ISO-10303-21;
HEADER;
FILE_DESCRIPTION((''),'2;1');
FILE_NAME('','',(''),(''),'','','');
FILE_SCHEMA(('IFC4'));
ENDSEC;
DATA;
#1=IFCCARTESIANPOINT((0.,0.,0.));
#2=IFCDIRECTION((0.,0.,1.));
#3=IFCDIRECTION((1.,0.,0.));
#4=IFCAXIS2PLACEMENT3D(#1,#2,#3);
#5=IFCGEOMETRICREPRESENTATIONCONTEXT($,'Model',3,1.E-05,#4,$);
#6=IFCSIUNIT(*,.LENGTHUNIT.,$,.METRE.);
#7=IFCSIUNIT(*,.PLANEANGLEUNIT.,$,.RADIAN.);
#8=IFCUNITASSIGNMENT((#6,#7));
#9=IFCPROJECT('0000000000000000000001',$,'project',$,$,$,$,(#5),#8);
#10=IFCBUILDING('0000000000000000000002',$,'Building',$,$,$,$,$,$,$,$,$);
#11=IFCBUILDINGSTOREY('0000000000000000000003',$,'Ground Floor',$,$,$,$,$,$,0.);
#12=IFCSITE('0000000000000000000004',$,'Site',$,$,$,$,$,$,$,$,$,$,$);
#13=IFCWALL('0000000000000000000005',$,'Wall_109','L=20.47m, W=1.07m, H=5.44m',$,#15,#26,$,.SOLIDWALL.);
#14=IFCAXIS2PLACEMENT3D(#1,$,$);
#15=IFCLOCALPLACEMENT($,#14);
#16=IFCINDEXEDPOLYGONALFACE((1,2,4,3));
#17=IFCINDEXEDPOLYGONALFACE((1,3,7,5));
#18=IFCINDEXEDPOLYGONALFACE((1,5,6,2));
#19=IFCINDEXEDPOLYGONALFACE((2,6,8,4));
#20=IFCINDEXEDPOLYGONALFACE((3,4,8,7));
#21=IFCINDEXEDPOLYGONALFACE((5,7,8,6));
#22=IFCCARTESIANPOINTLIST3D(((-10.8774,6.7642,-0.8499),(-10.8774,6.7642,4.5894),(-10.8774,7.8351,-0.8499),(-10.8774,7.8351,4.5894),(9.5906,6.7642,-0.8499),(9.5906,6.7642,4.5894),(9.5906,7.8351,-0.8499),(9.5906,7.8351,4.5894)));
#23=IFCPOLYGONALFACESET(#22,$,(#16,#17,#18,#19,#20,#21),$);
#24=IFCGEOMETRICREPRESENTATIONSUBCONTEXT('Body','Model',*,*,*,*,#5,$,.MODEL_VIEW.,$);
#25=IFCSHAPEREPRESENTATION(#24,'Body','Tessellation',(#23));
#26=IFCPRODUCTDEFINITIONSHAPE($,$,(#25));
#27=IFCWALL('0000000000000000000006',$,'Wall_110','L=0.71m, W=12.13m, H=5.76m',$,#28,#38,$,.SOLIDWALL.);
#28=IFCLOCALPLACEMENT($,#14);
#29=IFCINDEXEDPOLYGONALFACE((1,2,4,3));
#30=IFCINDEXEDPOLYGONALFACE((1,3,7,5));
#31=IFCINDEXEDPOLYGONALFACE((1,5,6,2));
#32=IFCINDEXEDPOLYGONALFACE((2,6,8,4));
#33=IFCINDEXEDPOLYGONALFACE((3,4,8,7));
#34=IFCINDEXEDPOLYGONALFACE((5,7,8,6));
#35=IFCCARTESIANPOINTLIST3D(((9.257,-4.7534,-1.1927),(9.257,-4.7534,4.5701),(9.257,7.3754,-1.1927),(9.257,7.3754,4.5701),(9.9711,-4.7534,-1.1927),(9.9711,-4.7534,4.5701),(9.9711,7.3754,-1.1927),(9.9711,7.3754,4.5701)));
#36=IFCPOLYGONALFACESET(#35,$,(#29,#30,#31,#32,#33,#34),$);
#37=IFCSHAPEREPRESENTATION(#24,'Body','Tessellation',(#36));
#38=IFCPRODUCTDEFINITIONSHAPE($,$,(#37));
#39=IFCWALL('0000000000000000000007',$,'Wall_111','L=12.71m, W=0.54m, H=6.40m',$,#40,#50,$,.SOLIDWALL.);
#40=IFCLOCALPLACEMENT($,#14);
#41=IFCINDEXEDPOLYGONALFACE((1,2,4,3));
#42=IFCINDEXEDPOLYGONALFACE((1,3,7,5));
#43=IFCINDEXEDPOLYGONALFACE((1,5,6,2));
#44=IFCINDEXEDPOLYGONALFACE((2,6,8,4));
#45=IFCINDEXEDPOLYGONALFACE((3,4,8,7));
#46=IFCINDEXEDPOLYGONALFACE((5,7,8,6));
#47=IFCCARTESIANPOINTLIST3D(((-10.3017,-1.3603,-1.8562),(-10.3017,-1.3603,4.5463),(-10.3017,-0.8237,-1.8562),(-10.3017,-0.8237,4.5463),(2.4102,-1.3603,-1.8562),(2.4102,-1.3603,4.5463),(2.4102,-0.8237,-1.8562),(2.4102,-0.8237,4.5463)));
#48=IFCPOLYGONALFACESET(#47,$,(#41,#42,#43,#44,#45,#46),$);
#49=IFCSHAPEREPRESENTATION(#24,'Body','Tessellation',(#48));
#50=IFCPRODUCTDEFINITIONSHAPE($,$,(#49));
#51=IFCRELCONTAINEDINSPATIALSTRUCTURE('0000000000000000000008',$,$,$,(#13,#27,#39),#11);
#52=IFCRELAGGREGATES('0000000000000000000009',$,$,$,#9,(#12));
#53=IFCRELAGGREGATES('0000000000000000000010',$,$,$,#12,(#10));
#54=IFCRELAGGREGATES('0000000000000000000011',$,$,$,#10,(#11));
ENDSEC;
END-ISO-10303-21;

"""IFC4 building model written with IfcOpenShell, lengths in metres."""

from ifc_helpers import new_model, si_unit, frame, origin_with_axes, origin_2d, context, subcontext, project, spatial, rectangle, extrude, element, save


model = new_model("IFC4")

# Units and contexts
model_context = context("Model", 3, precision=1e-05, world=origin_with_axes())
body_context = subcontext(model_context, "Body", "Model", "MODEL_VIEW")
ifc_project = project(units=[si_unit("LENGTHUNIT", "METRE"), si_unit("PLANEANGLEUNIT", "RADIAN")], contexts=[model_context])

# Site, building, storey
site = spatial("IfcSite", under=ifc_project, Name="Site")
building = spatial("IfcBuilding", under=site, Name="Building")
storey = spatial("IfcBuildingStorey", under=building, Name="Ground Floor", Elevation=0.0)

# Walls
element("IfcWall", 1, inside=storey, Name="Wall_109", Description="L=20.47m, W=1.07m, H=5.44m", PredefinedType="SOLIDWALL", context=body_context, shape_type="SweptSolid", body=[
    extrude(rectangle(XDim=20.468, YDim=1.0709, at=origin_2d()), frame((-0.6434, 7.2996, -0.8499), z_axis=(0.0, 0.0, 1.0), x_axis=(1.0, 0.0, 0.0)), (0.0, 0.0, 1.0), 5.4393),
])
element("IfcWall", 2, inside=storey, Name="Wall_110", Description="L=0.71m, W=12.13m, H=5.76m", PredefinedType="SOLIDWALL", context=body_context, shape_type="SweptSolid", body=[
    extrude(rectangle(XDim=0.7141, YDim=12.1288, at=origin_2d()), frame((9.614, 1.311, -1.1927), z_axis=(0.0, 0.0, 1.0), x_axis=(1.0, 0.0, 0.0)), (0.0, 0.0, 1.0), 5.7628),
])
element("IfcWall", 3, inside=storey, Name="Wall_111", Description="L=12.71m, W=0.54m, H=6.40m", PredefinedType="SOLIDWALL", context=body_context, shape_type="SweptSolid", body=[
    extrude(rectangle(XDim=12.7119, YDim=0.5366, at=origin_2d()), frame((-3.9457, -1.092, -1.8562), z_axis=(0.0, 0.0, 1.0), x_axis=(1.0, 0.0, 0.0)), (0.0, 0.0, 1.0), 6.4025),
])

save(model, "model.ifc")
